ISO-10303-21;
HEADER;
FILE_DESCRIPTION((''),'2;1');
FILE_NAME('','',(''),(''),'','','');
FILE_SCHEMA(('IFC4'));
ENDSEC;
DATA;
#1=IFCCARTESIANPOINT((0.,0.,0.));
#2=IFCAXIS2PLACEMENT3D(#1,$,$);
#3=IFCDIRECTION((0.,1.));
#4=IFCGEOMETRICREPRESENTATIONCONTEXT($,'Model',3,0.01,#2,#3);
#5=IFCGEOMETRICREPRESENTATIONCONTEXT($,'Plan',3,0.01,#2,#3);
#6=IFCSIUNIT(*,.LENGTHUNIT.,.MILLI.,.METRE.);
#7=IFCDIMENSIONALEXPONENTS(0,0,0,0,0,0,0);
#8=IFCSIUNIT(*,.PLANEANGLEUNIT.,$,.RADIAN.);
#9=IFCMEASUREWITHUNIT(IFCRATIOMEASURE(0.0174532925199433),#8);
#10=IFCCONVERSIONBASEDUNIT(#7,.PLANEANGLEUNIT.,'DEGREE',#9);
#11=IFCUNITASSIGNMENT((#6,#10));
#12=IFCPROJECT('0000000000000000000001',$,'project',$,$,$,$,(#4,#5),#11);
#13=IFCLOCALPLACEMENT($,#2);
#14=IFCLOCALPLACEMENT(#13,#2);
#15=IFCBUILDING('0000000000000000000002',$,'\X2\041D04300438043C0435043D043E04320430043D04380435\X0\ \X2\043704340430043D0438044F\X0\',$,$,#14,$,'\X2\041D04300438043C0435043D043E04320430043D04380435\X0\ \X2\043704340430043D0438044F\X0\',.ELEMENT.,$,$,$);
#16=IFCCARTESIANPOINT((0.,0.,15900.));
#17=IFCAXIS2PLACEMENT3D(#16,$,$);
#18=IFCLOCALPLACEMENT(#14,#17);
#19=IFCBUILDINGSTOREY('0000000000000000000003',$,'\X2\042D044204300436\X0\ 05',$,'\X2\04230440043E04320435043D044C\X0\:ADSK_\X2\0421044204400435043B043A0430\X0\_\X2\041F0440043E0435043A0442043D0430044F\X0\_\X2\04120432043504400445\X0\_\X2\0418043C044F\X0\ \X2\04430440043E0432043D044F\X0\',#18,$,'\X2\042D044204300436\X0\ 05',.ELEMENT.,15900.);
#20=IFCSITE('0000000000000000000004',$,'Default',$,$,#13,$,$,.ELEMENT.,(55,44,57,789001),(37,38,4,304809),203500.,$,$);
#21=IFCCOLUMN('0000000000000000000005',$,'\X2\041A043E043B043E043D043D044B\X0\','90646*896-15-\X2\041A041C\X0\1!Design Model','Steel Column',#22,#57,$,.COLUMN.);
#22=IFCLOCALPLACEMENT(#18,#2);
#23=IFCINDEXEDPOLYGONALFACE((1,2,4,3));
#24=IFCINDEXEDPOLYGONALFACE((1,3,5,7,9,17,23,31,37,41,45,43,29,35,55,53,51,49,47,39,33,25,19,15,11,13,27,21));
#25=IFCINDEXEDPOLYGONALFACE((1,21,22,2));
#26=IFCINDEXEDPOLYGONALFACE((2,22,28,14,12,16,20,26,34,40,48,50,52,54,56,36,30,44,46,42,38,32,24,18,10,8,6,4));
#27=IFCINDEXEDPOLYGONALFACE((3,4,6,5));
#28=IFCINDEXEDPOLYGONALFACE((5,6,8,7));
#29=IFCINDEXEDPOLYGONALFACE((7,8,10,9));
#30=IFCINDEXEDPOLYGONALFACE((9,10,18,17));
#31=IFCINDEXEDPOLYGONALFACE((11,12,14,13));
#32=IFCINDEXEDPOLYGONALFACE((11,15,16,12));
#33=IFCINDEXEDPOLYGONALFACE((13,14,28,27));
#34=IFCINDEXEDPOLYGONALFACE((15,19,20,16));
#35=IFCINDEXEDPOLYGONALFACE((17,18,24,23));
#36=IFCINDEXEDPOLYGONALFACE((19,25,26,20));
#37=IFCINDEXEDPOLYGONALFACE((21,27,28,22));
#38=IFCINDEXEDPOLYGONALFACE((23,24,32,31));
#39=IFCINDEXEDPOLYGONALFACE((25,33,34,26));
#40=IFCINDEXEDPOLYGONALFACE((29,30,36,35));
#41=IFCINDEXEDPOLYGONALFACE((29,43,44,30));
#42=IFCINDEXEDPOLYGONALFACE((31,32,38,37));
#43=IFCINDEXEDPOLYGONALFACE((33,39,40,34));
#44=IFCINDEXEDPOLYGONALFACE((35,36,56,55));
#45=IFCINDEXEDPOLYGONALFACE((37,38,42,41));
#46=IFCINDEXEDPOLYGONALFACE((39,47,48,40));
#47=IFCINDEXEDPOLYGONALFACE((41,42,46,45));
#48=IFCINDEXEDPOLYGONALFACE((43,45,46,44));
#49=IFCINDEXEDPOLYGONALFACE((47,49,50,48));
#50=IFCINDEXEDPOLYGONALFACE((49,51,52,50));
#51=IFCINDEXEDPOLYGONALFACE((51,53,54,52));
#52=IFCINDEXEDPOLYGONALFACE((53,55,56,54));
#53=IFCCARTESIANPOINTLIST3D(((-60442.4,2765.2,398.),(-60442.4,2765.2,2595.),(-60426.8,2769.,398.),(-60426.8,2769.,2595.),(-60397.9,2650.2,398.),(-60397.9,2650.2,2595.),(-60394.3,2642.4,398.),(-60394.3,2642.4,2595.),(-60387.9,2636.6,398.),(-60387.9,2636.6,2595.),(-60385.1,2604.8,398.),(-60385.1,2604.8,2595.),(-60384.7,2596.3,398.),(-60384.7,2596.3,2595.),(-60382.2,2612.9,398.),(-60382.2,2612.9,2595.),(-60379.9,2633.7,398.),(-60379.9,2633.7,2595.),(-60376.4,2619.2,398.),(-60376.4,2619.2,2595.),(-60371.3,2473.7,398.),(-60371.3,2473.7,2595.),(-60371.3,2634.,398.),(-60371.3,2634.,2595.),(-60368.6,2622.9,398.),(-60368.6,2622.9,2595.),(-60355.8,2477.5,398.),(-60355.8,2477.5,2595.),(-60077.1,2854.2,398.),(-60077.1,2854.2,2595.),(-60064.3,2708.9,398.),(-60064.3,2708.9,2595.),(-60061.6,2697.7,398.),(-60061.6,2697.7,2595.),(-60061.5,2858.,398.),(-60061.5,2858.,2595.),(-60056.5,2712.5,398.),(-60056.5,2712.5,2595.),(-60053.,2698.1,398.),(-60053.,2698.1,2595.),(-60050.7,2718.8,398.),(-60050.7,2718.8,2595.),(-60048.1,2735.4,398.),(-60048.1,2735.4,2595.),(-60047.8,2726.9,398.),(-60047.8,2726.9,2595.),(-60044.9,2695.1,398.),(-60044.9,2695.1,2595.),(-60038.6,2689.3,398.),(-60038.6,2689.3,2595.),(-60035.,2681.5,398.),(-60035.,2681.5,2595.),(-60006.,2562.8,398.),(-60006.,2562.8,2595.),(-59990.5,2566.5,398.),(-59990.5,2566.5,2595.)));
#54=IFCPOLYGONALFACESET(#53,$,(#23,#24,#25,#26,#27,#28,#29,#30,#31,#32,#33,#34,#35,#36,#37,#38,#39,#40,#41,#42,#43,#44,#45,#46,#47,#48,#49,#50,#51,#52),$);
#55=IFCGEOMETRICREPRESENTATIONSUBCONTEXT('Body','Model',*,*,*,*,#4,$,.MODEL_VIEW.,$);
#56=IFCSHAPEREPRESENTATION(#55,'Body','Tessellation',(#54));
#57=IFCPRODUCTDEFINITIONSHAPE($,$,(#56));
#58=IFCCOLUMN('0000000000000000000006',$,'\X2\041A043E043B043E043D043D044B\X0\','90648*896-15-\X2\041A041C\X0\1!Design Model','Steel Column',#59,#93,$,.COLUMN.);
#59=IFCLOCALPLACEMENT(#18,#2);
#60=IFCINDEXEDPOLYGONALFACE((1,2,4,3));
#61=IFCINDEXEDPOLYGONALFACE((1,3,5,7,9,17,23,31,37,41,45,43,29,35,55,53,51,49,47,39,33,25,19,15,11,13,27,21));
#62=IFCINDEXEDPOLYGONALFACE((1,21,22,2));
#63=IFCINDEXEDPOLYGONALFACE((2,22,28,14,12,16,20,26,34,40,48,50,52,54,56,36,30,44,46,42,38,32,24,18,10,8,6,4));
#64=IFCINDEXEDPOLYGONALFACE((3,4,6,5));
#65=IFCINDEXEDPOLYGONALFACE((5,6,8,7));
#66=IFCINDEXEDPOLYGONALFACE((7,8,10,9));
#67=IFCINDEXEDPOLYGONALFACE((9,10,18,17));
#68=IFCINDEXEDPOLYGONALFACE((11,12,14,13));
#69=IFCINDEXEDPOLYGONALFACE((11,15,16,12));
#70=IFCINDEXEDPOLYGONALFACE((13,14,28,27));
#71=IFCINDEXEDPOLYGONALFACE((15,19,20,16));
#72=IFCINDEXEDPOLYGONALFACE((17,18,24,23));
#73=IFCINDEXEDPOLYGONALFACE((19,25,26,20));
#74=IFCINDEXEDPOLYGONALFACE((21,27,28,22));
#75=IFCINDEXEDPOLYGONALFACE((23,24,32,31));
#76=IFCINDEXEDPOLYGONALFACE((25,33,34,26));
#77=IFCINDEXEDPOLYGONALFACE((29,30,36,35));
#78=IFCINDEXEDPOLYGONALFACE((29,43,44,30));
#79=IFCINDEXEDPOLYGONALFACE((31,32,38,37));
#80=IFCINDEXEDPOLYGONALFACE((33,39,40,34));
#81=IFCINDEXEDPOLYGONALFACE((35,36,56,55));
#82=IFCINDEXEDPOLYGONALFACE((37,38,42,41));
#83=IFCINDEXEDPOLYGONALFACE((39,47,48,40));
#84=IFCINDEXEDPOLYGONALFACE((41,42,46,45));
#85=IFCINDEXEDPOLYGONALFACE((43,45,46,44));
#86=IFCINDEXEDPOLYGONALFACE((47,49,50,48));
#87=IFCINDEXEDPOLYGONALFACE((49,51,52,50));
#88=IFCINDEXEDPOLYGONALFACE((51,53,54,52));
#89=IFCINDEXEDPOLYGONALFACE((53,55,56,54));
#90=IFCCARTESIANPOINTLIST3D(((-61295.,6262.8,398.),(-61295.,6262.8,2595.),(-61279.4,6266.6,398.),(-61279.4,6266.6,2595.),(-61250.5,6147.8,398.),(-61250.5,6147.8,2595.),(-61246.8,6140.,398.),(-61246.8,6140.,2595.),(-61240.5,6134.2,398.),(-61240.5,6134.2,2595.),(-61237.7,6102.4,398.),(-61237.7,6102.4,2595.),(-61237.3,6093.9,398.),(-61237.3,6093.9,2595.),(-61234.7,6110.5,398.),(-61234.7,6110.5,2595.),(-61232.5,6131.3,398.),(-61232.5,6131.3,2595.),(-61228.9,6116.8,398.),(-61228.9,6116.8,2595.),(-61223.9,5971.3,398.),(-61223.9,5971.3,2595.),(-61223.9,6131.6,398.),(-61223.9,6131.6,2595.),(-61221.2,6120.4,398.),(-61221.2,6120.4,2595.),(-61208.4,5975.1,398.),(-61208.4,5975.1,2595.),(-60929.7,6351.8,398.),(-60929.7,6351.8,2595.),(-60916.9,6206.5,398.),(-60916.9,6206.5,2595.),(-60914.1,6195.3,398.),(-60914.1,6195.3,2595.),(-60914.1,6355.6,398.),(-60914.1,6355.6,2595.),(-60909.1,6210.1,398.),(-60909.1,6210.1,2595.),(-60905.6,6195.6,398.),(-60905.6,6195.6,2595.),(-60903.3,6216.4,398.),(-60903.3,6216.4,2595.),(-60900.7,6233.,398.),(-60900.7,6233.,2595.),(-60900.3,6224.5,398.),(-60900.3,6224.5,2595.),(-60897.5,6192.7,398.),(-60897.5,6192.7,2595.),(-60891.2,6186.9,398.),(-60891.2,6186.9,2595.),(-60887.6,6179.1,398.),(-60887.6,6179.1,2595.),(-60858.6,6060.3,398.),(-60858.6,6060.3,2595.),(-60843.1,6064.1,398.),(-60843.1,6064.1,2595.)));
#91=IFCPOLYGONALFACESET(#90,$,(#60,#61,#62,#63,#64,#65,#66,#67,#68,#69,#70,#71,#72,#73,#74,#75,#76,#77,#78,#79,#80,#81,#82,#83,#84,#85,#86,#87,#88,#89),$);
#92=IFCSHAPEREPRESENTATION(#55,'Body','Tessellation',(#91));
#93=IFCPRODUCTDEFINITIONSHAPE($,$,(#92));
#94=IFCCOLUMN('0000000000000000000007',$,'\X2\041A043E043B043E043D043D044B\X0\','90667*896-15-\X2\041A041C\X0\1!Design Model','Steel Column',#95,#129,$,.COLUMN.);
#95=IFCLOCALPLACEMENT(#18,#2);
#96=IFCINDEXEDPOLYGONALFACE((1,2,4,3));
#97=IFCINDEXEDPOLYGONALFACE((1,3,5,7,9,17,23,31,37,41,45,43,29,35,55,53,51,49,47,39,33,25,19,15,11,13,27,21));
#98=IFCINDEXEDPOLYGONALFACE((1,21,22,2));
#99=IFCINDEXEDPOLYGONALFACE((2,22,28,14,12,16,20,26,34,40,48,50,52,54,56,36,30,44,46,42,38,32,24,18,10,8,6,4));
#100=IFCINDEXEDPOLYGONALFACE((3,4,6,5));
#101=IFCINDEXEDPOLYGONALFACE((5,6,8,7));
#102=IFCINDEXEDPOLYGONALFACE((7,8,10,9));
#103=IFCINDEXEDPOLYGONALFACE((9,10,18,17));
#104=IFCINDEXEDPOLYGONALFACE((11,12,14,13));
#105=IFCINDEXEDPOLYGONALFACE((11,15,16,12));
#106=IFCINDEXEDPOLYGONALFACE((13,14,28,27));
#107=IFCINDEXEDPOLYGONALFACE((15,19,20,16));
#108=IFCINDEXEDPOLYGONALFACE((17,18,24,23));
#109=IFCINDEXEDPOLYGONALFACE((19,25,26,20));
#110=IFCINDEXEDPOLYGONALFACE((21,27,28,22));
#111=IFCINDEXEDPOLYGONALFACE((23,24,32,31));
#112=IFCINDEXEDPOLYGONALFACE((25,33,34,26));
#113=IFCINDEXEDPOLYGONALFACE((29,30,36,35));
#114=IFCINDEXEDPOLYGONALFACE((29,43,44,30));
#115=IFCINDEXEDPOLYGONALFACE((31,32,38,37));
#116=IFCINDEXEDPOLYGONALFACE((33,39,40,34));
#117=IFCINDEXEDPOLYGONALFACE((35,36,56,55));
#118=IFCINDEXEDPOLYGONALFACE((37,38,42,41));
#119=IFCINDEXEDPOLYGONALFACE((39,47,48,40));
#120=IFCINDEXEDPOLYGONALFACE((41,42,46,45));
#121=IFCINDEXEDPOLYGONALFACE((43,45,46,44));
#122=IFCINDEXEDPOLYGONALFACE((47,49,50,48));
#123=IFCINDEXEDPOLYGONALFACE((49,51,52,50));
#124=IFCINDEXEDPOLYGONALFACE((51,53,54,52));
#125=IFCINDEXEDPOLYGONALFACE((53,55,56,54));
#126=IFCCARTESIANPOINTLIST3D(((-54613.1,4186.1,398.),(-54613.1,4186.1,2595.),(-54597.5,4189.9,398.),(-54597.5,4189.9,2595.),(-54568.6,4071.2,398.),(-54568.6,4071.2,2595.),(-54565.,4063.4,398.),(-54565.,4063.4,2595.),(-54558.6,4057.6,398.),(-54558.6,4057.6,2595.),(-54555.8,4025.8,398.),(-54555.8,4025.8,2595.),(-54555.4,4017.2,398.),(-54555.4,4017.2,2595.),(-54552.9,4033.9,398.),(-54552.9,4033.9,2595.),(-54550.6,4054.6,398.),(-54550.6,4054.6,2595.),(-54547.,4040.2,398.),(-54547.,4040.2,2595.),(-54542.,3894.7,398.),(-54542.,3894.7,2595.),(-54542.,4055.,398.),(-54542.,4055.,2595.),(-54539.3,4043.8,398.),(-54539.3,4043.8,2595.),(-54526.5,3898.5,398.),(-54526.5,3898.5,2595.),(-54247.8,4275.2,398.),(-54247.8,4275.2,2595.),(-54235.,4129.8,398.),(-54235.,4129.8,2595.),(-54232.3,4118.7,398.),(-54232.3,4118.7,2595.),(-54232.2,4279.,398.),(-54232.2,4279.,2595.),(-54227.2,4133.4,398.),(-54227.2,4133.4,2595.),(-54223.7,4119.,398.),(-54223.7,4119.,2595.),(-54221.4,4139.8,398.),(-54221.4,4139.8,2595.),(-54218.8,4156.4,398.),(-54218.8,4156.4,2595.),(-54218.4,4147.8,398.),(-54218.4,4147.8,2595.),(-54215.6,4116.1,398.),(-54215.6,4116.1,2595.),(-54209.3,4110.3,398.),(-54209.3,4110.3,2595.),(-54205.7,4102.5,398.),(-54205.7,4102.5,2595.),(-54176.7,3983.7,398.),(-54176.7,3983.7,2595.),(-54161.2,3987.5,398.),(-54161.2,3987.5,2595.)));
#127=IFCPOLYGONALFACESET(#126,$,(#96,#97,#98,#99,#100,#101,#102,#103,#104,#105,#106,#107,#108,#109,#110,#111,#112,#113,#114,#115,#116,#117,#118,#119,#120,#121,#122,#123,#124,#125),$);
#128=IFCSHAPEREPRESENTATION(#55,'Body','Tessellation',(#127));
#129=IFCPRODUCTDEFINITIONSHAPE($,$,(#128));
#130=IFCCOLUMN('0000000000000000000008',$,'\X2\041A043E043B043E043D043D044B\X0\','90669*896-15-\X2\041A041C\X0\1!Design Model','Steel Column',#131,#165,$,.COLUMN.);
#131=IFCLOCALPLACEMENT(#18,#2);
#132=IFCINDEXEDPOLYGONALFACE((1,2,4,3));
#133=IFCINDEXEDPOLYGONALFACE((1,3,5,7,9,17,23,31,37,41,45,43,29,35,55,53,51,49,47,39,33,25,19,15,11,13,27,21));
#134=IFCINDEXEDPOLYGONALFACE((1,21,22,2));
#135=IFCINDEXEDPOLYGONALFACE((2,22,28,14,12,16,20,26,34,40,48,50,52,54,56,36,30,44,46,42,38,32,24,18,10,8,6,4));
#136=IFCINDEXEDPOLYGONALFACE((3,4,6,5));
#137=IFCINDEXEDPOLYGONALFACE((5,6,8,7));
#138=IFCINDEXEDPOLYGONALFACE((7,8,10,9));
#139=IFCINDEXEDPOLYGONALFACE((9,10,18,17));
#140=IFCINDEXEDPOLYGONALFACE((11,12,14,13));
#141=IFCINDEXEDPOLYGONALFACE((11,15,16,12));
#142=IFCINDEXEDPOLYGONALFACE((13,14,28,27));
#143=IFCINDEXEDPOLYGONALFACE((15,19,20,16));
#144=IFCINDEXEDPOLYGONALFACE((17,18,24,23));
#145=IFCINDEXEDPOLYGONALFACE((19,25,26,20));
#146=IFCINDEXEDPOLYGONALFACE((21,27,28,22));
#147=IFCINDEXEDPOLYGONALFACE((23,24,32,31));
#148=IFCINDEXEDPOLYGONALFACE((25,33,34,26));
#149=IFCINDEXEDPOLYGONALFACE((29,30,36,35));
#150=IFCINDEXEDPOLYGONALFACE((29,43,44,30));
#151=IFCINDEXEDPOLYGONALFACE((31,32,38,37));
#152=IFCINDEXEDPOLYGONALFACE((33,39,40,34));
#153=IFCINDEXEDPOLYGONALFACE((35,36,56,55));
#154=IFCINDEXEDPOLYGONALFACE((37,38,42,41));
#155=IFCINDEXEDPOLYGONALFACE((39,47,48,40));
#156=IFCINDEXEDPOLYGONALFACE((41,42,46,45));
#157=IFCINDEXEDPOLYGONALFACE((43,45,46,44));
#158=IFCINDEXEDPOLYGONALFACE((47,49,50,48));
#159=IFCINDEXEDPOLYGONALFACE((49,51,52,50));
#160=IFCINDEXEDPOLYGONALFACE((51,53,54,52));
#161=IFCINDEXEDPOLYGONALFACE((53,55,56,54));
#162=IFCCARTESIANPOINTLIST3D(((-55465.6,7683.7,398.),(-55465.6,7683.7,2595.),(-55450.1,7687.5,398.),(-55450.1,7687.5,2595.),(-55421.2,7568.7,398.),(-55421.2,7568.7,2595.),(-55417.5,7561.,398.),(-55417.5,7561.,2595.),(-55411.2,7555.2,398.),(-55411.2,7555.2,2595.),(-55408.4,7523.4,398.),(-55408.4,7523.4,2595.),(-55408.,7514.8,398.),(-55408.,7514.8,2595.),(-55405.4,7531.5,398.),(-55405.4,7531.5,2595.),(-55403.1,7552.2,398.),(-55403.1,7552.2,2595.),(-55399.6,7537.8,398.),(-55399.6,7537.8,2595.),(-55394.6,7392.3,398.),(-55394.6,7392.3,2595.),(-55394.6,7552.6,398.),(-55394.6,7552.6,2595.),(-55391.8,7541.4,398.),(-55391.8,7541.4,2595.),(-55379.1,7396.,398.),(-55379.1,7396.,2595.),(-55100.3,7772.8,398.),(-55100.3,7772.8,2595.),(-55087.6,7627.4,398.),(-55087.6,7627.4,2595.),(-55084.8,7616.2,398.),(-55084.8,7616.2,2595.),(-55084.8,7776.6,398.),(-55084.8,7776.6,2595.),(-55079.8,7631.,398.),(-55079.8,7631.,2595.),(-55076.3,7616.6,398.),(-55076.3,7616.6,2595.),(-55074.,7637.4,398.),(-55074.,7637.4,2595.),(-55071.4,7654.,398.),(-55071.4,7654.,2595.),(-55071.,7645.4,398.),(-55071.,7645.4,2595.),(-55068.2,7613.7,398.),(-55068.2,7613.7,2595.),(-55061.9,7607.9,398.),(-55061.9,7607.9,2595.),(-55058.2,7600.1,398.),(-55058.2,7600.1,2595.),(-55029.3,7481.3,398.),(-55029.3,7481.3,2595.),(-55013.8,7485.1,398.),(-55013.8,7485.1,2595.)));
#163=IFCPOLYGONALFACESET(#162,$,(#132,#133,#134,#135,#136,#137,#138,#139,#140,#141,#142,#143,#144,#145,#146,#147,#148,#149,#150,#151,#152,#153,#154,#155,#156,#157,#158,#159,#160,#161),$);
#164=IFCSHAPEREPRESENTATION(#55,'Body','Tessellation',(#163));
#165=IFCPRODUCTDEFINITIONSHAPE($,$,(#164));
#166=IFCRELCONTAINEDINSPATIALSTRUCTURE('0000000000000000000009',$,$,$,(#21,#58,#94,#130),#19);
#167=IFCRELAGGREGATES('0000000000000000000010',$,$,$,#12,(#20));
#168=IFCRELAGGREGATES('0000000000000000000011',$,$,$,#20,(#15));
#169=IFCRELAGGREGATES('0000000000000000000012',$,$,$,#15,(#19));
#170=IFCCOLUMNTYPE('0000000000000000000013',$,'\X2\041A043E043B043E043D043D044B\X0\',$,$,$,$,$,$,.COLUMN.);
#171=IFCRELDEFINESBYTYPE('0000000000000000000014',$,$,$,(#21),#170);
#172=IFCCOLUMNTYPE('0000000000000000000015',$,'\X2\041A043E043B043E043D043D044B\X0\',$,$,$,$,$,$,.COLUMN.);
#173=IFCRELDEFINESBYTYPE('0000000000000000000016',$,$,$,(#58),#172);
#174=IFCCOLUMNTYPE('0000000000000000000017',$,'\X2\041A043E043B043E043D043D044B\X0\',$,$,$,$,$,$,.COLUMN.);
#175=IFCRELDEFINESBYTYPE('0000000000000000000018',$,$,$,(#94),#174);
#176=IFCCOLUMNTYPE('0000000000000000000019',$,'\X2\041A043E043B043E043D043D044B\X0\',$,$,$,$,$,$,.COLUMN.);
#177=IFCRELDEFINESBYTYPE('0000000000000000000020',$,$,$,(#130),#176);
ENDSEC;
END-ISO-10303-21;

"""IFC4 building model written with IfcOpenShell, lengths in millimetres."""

from ifc_helpers import new_model, entity, si_unit, converted_unit, direction, frame, origin, place, context, subcontext, project, spatial, indexed_curve, outline, extrude, type_object, element, save


model = new_model("IFC4")

# Units and contexts
model_context = context("Model", 3, precision=0.01, world=origin(), true_north=direction((0.0, 1.0)))
plan_context = context("Plan", 3, precision=0.01, world=origin(), true_north=direction((0.0, 1.0)))
body_context = subcontext(model_context, "Body", "Model", "MODEL_VIEW")
ifc_project = project(units=[si_unit("LENGTHUNIT", "METRE", prefix="MILLI"), converted_unit("PLANEANGLEUNIT", "DEGREE", entity("IfcRatioMeasure", 0.0174532925199433), si_unit("PLANEANGLEUNIT", "RADIAN"), dimensions=[0, 0, 0, 0, 0, 0, 0])], contexts=[model_context, plan_context])

# Site, building, storey
site_placement = place(None, origin())
site = spatial("IfcSite", under=ifc_project, at=site_placement, Name="Default", CompositionType="ELEMENT", RefLatitude=(55, 44, 57, 789001), RefLongitude=(37, 38, 4, 304809), RefElevation=203500.0)
building_placement = place(site_placement, origin())
building = spatial("IfcBuilding", under=site, at=building_placement, Name="Наименование здания", LongName="Наименование здания", CompositionType="ELEMENT")
storey_placement = place(building_placement, frame((0.0, 0.0, 15900.0)))
storey = spatial("IfcBuildingStorey", under=building, at=storey_placement, Name="Этаж 05", ObjectType="Уровень:ADSK_Стрелка_Проектная_Вверх_Имя уровня", LongName="Этаж 05", CompositionType="ELEMENT", Elevation=15900.0)

# Columns
column_type_1 = type_object("IfcColumnType", Name="Колонны", PredefinedType="COLUMN")
placement = place(storey_placement, origin())
element("IfcColumn", 1, at=placement, inside=storey, type_object=column_type_1, Name="Колонны", Description="90646*896-15-КМ1!Design Model", ObjectType="Steel Column", PredefinedType="COLUMN", context=body_context, shape_type="SweptSolid", body=[
    extrude(outline(indexed_curve([(-196.0, -150.0), (-180.0, -150.0), (-180.0, -27.7), (-178.3, -19.3), (-173.6, -12.2), (-166.4, -7.4), (-158.0, -5.7), (158.0, -5.8), (166.4, -7.4), (173.6, -12.2), (178.3, -19.3), (180.0, -27.8), (180.0, -150.0), (196.0, -150.0), (196.0, 150.0), (180.0, 150.0), (180.0, 27.7), (178.3, 19.3), (173.6, 12.2), (166.4, 7.4), (158.0, 5.7), (-158.0, 5.8), (-166.4, 7.4), (-173.6, 12.2), (-178.3, 19.3), (-180.0, 27.8), (-180.0, 150.0), (-196.0, 150.0), (-196.0, -150.0)], self_intersect=False)), frame((-60216.4, 2665.9, 398.0), z_axis=(0.0, 0.0, 1.0), x_axis=(-0.971552, -0.236826, 0.0)), (0.0, 0.0, 1.0), 2197.0),
])
column_type_2 = type_object("IfcColumnType", Name="Колонны", PredefinedType="COLUMN")
element("IfcColumn", 2, at=placement, inside=storey, type_object=column_type_2, Name="Колонны", Description="90648*896-15-КМ1!Design Model", ObjectType="Steel Column", PredefinedType="COLUMN", context=body_context, shape_type="SweptSolid", body=[
    extrude(outline(indexed_curve([(-196.0, -150.0), (-180.0, -150.0), (-180.0, -27.8), (-178.3, -19.3), (-173.6, -12.2), (-166.4, -7.4), (-158.0, -5.8), (158.0, -5.7), (166.4, -7.4), (173.6, -12.2), (178.3, -19.3), (180.0, -27.7), (180.0, -150.0), (196.0, -150.0), (196.0, 150.0), (180.0, 150.0), (180.0, 27.8), (178.3, 19.3), (173.6, 12.2), (166.4, 7.4), (158.0, 5.8), (-158.0, 5.8), (-166.4, 7.4), (-173.6, 12.2), (-178.3, 19.3), (-180.0, 27.8), (-180.0, 150.0), (-196.0, 150.0), (-196.0, -150.0)], self_intersect=False)), frame((-61069.0, 6163.4, 398.0), z_axis=(0.0, 0.0, 1.0), x_axis=(-0.971552, -0.236826, 0.0)), (0.0, 0.0, 1.0), 2197.0),
])
column_type_3 = type_object("IfcColumnType", Name="Колонны", PredefinedType="COLUMN")
element("IfcColumn", 3, at=placement, inside=storey, type_object=column_type_3, Name="Колонны", Description="90667*896-15-КМ1!Design Model", ObjectType="Steel Column", PredefinedType="COLUMN", context=body_context, shape_type="SweptSolid", body=[
    extrude(outline(indexed_curve([(-196.0, -150.0), (-180.0, -150.0), (-180.0, -27.7), (-178.3, -19.3), (-173.6, -12.2), (-166.4, -7.4), (-158.0, -5.7), (158.0, -5.8), (166.4, -7.4), (173.6, -12.2), (178.3, -19.3), (180.0, -27.8), (180.0, -150.0), (196.0, -150.0), (196.0, 150.0), (180.0, 150.0), (180.0, 27.7), (178.3, 19.3), (173.6, 12.2), (166.4, 7.4), (158.0, 5.7), (-158.0, 5.8), (-166.4, 7.4), (-173.6, 12.2), (-178.3, 19.3), (-180.0, 27.8), (-180.0, 150.0), (-196.0, 150.0), (-196.0, -150.0)], self_intersect=False)), frame((-54387.1, 4086.8, 398.0), z_axis=(0.0, 0.0, 1.0), x_axis=(-0.971552, -0.236826, 0.0)), (0.0, 0.0, 1.0), 2197.0),
])
column_type_4 = type_object("IfcColumnType", Name="Колонны", PredefinedType="COLUMN")
element("IfcColumn", 4, at=placement, inside=storey, type_object=column_type_4, Name="Колонны", Description="90669*896-15-КМ1!Design Model", ObjectType="Steel Column", PredefinedType="COLUMN", context=body_context, shape_type="SweptSolid", body=[
    extrude(outline(indexed_curve([(-196.0, -150.0), (-180.0, -150.0), (-180.0, -27.8), (-178.3, -19.3), (-173.6, -12.2), (-166.4, -7.4), (-158.0, -5.8), (158.0, -5.8), (166.4, -7.4), (173.6, -12.2), (178.3, -19.3), (180.0, -27.8), (180.0, -150.0), (196.0, -150.0), (196.0, 150.0), (180.0, 150.0), (180.0, 27.7), (178.3, 19.3), (173.6, 12.2), (166.4, 7.4), (158.0, 5.7), (-158.0, 5.7), (-166.4, 7.4), (-173.6, 12.2), (-178.3, 19.3), (-180.0, 27.7), (-180.0, 150.0), (-196.0, 150.0), (-196.0, -150.0)], self_intersect=False)), frame((-55239.7, 7584.4, 398.0), z_axis=(0.0, 0.0, 1.0), x_axis=(-0.971552, -0.236826, 0.0)), (0.0, 0.0, 1.0), 2197.0),
])

save(model, "model.ifc")
